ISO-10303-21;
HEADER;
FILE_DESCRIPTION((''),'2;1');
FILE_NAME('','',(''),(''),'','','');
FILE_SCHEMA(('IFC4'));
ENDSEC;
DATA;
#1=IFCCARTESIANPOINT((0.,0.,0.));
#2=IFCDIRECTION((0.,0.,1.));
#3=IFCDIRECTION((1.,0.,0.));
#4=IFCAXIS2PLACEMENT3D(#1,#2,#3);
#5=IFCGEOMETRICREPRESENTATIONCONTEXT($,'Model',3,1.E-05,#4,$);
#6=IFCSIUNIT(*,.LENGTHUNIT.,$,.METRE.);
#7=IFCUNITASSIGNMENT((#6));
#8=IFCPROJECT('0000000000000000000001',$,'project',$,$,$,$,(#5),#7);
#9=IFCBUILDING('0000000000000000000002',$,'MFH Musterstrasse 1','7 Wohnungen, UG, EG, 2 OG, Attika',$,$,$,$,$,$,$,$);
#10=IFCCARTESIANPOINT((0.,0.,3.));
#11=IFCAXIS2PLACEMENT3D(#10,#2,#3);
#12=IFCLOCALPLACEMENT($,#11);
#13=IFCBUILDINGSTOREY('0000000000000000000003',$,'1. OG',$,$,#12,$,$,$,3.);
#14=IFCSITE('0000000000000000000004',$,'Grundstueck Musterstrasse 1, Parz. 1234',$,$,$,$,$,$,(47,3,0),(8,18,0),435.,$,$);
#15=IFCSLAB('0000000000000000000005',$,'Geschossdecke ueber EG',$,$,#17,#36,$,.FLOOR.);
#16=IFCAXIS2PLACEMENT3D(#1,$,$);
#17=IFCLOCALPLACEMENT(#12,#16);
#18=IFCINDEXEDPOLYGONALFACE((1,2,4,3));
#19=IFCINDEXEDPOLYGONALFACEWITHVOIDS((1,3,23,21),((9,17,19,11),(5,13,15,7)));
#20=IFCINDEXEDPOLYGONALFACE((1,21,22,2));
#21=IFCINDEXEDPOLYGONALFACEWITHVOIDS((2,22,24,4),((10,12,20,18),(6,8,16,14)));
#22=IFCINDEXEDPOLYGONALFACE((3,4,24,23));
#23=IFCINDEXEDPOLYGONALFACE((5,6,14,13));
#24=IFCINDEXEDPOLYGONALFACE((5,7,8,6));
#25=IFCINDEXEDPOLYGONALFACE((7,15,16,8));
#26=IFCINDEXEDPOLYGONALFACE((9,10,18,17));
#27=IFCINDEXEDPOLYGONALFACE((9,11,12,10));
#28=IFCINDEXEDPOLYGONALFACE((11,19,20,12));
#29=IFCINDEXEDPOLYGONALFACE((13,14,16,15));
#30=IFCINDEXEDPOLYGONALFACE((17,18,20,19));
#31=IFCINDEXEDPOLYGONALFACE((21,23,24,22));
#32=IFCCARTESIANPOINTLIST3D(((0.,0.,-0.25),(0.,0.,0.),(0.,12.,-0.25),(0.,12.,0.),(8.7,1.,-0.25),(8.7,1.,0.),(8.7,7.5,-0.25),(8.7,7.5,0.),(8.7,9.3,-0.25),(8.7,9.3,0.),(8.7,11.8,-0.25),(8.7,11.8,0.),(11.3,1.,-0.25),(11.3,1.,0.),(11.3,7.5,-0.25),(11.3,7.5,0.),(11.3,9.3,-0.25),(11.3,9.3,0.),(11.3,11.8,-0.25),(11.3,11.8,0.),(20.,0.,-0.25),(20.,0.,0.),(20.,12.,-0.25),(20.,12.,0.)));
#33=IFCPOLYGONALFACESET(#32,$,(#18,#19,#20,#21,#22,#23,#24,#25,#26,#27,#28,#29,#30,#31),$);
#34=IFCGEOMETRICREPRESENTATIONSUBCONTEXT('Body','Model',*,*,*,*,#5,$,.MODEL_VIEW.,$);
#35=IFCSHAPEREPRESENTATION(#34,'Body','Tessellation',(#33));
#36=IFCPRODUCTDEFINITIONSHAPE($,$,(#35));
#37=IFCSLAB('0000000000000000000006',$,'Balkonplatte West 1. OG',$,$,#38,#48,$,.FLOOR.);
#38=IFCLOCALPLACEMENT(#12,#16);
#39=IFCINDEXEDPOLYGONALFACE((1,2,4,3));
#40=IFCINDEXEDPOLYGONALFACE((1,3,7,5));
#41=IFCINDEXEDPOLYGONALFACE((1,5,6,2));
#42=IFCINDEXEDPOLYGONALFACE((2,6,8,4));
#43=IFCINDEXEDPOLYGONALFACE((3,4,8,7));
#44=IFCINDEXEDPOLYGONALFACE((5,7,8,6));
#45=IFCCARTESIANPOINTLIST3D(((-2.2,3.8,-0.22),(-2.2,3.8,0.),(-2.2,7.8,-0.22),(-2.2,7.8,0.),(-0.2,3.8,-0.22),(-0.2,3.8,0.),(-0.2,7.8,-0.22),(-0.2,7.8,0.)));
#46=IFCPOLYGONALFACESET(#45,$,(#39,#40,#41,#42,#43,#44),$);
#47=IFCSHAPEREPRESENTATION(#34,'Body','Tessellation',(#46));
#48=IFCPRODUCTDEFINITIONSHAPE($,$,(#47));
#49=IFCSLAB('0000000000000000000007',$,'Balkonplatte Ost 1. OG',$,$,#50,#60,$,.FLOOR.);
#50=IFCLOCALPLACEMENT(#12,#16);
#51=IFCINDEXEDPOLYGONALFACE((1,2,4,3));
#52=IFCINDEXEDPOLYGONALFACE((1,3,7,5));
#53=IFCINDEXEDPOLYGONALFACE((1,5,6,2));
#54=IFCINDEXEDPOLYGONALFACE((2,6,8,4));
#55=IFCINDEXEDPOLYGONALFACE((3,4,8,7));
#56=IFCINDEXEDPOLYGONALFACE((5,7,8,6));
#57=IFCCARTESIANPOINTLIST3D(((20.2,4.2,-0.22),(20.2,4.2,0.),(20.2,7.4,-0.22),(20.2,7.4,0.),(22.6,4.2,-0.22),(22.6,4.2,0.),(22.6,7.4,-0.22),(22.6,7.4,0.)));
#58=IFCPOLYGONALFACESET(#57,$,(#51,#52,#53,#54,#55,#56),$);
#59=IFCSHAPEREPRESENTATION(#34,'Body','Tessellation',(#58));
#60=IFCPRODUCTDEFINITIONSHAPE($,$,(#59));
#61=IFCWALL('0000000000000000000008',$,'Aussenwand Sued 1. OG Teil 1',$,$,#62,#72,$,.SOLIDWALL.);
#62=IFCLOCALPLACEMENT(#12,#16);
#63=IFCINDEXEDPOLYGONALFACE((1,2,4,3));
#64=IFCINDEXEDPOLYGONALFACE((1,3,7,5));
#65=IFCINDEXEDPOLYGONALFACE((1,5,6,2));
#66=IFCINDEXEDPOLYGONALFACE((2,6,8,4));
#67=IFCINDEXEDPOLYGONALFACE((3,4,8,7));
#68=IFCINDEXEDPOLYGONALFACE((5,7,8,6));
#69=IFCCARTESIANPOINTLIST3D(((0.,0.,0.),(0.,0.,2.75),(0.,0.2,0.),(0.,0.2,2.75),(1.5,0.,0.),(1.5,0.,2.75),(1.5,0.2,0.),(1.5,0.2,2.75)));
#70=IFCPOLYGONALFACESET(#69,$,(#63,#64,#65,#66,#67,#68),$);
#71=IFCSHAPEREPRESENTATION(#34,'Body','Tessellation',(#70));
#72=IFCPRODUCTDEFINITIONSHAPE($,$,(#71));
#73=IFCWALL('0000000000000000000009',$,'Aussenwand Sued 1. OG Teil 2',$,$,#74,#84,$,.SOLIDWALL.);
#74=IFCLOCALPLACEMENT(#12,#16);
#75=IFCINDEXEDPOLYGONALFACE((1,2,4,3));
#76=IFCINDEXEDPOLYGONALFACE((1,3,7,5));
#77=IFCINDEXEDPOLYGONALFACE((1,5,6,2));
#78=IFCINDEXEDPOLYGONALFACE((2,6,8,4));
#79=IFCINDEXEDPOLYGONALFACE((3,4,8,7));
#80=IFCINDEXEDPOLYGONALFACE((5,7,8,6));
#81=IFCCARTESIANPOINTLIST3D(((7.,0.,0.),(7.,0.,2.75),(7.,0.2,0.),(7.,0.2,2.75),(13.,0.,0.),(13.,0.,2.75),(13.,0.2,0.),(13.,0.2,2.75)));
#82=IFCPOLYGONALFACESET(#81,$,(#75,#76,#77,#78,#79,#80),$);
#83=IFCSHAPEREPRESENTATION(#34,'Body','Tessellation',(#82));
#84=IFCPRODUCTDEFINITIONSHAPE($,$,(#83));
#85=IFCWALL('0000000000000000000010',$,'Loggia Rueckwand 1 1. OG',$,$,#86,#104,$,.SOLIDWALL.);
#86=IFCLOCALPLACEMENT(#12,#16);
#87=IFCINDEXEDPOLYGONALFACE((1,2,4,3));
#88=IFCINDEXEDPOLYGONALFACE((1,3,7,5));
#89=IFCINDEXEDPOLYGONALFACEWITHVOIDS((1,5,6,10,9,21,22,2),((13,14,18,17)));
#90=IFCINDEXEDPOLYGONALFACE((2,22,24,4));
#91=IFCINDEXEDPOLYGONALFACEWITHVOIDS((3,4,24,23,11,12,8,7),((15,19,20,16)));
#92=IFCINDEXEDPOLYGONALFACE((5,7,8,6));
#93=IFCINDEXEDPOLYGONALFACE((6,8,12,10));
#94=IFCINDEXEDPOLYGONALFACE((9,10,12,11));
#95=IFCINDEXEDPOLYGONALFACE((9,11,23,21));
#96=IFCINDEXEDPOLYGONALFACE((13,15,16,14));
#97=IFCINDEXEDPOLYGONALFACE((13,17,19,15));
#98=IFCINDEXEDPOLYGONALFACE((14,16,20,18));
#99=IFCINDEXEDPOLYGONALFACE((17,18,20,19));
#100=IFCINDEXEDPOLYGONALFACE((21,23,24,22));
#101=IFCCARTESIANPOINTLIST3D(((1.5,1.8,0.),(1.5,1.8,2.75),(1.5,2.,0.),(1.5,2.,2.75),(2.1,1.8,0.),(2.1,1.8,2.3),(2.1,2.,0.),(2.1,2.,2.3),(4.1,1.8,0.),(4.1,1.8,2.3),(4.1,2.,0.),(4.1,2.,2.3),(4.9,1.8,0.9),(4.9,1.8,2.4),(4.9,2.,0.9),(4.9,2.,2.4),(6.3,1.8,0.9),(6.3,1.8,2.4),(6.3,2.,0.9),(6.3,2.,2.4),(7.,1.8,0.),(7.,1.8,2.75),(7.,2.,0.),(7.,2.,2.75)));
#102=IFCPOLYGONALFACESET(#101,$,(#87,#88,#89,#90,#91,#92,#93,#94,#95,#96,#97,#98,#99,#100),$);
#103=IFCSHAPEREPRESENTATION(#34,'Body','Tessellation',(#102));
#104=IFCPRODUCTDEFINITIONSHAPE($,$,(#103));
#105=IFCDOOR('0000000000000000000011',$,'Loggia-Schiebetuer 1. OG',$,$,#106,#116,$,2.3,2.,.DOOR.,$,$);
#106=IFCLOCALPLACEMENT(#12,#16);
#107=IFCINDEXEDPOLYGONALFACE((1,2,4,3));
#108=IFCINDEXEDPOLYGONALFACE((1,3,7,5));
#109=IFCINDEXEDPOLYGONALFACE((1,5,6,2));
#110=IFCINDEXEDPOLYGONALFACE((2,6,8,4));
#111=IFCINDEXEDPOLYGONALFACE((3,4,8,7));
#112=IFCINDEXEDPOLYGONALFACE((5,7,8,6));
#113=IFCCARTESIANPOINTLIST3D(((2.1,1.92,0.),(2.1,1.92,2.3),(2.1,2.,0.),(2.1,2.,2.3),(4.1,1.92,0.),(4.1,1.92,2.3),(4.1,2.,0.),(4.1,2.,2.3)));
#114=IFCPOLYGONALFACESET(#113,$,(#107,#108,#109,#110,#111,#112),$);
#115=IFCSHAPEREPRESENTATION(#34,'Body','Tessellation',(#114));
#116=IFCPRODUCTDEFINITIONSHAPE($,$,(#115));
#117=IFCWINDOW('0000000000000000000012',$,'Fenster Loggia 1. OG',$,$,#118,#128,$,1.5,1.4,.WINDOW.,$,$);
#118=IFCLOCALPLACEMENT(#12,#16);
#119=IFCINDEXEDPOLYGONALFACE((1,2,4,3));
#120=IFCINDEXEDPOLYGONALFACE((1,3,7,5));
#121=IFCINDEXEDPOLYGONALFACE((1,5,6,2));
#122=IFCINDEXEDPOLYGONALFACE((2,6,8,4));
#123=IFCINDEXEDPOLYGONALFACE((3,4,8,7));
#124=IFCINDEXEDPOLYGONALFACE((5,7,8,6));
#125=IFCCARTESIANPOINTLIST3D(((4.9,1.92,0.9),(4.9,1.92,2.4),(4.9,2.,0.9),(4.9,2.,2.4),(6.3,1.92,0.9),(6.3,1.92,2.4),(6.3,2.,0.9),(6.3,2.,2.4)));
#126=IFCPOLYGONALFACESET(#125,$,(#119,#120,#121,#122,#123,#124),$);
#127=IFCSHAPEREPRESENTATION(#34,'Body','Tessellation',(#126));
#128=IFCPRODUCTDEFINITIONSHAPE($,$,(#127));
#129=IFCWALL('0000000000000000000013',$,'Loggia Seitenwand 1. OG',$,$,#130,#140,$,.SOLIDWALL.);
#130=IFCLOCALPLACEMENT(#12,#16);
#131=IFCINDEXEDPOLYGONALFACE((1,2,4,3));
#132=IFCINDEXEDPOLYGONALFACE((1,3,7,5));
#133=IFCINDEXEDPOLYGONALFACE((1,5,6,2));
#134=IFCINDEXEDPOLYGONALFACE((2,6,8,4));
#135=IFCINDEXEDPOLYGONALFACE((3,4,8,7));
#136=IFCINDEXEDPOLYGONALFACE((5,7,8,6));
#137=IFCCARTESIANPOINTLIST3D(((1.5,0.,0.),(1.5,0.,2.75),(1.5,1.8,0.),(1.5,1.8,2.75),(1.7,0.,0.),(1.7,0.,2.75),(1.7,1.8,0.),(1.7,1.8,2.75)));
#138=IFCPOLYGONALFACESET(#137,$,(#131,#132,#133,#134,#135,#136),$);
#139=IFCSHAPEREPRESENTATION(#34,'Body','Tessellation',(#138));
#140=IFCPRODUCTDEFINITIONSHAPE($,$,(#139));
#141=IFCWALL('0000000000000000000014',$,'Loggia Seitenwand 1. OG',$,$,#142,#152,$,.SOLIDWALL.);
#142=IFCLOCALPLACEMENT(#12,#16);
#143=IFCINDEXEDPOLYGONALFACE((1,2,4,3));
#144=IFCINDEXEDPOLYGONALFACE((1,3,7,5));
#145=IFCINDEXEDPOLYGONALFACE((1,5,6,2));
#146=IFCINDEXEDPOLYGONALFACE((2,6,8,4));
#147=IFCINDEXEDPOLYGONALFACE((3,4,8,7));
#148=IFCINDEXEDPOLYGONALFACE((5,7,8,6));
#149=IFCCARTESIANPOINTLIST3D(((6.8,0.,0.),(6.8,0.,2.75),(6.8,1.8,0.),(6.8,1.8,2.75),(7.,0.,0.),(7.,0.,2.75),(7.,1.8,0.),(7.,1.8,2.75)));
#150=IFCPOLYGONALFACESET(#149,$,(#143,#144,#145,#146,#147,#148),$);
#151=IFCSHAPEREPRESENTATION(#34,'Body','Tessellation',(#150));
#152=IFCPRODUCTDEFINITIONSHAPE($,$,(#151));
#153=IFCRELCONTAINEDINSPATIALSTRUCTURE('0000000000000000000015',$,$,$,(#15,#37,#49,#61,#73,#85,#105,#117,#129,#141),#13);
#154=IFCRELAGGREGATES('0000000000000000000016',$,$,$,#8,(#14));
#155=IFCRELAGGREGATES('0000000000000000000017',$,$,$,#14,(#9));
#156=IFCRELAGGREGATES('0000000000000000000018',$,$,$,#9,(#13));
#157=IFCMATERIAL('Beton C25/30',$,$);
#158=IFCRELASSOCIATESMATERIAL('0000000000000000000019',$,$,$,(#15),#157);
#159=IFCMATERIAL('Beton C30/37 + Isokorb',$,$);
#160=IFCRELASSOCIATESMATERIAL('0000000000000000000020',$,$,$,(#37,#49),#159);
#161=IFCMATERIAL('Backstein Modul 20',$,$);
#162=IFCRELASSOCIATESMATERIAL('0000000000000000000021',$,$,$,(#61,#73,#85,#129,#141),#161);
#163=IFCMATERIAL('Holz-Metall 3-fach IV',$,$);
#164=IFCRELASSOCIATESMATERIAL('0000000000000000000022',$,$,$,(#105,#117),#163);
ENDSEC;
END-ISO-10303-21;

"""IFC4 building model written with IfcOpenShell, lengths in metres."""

from ifc_helpers import new_model, si_unit, frame, frame_2d, origin_with_axes, place, context, subcontext, project, spatial, polyline, rectangle, outline, extrude, material, element, fill, save


model = new_model("IFC4")

# Units and contexts
model_context = context("Model", 3, precision=1e-05, world=origin_with_axes())
body_context = subcontext(model_context, "Body", "Model", "MODEL_VIEW")
ifc_project = project(units=[si_unit("LENGTHUNIT", "METRE")], contexts=[model_context])

# Site, building, storey
site = spatial("IfcSite", under=ifc_project, Name="Grundstueck Musterstrasse 1, Parz. 1234", RefLatitude=(47, 3, 0), RefLongitude=(8, 18, 0), RefElevation=435.0)
building = spatial("IfcBuilding", under=site, Name="MFH Musterstrasse 1", Description="7 Wohnungen, UG, EG, 2 OG, Attika")
storey_placement = place(None, frame((0.0, 0.0, 3.0), z_axis=(0.0, 0.0, 1.0), x_axis=(1.0, 0.0, 0.0)))
storey = spatial("IfcBuildingStorey", under=building, at=storey_placement, Name="1. OG", Elevation=3.0)

# Slab, openings
ifc_material_1 = material(Name="Beton C25/30")
slab_1_placement = place(storey_placement, frame((0.0, 0.0, -0.25), z_axis=(0.0, 0.0, 1.0), x_axis=(1.0, 0.0, 0.0)))
slab_1 = element("IfcSlab", 1, at=slab_1_placement, inside=storey, material=ifc_material_1, Name="Geschossdecke ueber EG", PredefinedType="FLOOR", context=body_context, shape_type="SweptSolid", body=[
    extrude(outline(polyline([(0.0, 0.0), (20.0, 0.0), (20.0, 12.0), (0.0, 12.0), (0.0, 0.0)])), origin_with_axes(), (0.0, 0.0, 1.0), 0.25),
])
opening_1_placement = place(slab_1_placement, frame((8.7, 1.0, -0.01), z_axis=(0.0, 0.0, 1.0), x_axis=(1.0, 0.0, 0.0)))
element("IfcOpeningElement", 2, at=opening_1_placement, cuts=slab_1, context=body_context, shape_type="SweptSolid", body=[
    extrude(rectangle(XDim=2.6, YDim=6.5, at=frame_2d((1.3, 3.25))), origin_with_axes(), (0.0, 0.0, 1.0), 0.27),
])
opening_2_placement = place(slab_1_placement, frame((8.7, 9.3, -0.01), z_axis=(0.0, 0.0, 1.0), x_axis=(1.0, 0.0, 0.0)))
element("IfcOpeningElement", 3, at=opening_2_placement, cuts=slab_1, context=body_context, shape_type="SweptSolid", body=[
    extrude(rectangle(XDim=2.6, YDim=2.5, at=frame_2d((1.3, 1.25))), origin_with_axes(), (0.0, 0.0, 1.0), 0.27),
])

# Slabs
ifc_material_2 = material(Name="Beton C30/37 + Isokorb")
slab_2_placement = place(storey_placement, frame((0.0, 0.0, -0.22), z_axis=(0.0, 0.0, 1.0), x_axis=(1.0, 0.0, 0.0)))
element("IfcSlab", 4, at=slab_2_placement, inside=storey, material=ifc_material_2, Name="Balkonplatte West 1. OG", PredefinedType="FLOOR", context=body_context, shape_type="SweptSolid", body=[
    extrude(outline(polyline([(-2.2, 3.8), (-0.2, 3.8), (-0.2, 7.8), (-2.2, 7.8), (-2.2, 3.8)])), origin_with_axes(), (0.0, 0.0, 1.0), 0.22),
])
slab_3_placement = place(storey_placement, frame((0.0, 0.0, -0.22), z_axis=(0.0, 0.0, 1.0), x_axis=(1.0, 0.0, 0.0)))
element("IfcSlab", 5, at=slab_3_placement, inside=storey, material=ifc_material_2, Name="Balkonplatte Ost 1. OG", PredefinedType="FLOOR", context=body_context, shape_type="SweptSolid", body=[
    extrude(outline(polyline([(20.2, 4.2), (22.6, 4.2), (22.6, 7.4), (20.2, 7.4), (20.2, 4.2)])), origin_with_axes(), (0.0, 0.0, 1.0), 0.22),
])

# Walls
ifc_material_3 = material(Name="Backstein Modul 20")
wall_1_placement = place(storey_placement, origin_with_axes())
element("IfcWall", 6, at=wall_1_placement, inside=storey, material=ifc_material_3, Name="Aussenwand Sued 1. OG Teil 1", PredefinedType="SOLIDWALL", context=body_context, shape_type="SweptSolid", body=[
    extrude(rectangle(XDim=1.5, YDim=0.2, at=frame_2d((0.75, 0.1))), origin_with_axes(), (0.0, 0.0, 1.0), 2.75),
])
wall_2_placement = place(storey_placement, frame((7.0, 0.0, 0.0), z_axis=(0.0, 0.0, 1.0), x_axis=(1.0, 0.0, 0.0)))
element("IfcWall", 7, at=wall_2_placement, inside=storey, material=ifc_material_3, Name="Aussenwand Sued 1. OG Teil 2", PredefinedType="SOLIDWALL", context=body_context, shape_type="SweptSolid", body=[
    extrude(rectangle(XDim=6.0, YDim=0.2, at=frame_2d((3.0, 0.1))), origin_with_axes(), (0.0, 0.0, 1.0), 2.75),
])

# Wall, openings, door, window
wall_3_placement = place(storey_placement, frame((1.5, 1.8, 0.0), z_axis=(0.0, 0.0, 1.0), x_axis=(1.0, 0.0, 0.0)))
wall_3 = element("IfcWall", 8, at=wall_3_placement, inside=storey, material=ifc_material_3, Name="Loggia Rueckwand 1 1. OG", PredefinedType="SOLIDWALL", context=body_context, shape_type="SweptSolid", body=[
    extrude(rectangle(XDim=5.5, YDim=0.2, at=frame_2d((2.75, 0.1))), origin_with_axes(), (0.0, 0.0, 1.0), 2.75),
])
opening_3_placement = place(wall_3_placement, frame((0.6, -0.21, 0.0), z_axis=(0.0, 0.0, 1.0), x_axis=(1.0, 0.0, 0.0)))
opening_3 = element("IfcOpeningElement", 9, at=opening_3_placement, cuts=wall_3, context=body_context, shape_type="SweptSolid", body=[
    extrude(rectangle(XDim=2.0, YDim=0.42, at=frame_2d((1.0, 0.21))), origin_with_axes(), (0.0, 0.0, 1.0), 2.3),
])
opening_4_placement = place(wall_3_placement, frame((3.4, -0.21, 0.9), z_axis=(0.0, 0.0, 1.0), x_axis=(1.0, 0.0, 0.0)))
opening_4 = element("IfcOpeningElement", 10, at=opening_4_placement, cuts=wall_3, context=body_context, shape_type="SweptSolid", body=[
    extrude(rectangle(XDim=1.4, YDim=0.42, at=frame_2d((0.7, 0.21))), origin_with_axes(), (0.0, 0.0, 1.0), 1.5),
])
ifc_material_4 = material(Name="Holz-Metall 3-fach IV")
door_1_placement = place(storey_placement, frame((2.1, 1.92, 0.0), z_axis=(0.0, 0.0, 1.0), x_axis=(1.0, 0.0, 0.0)))
door_1 = element("IfcDoor", 11, at=door_1_placement, inside=storey, material=ifc_material_4, Name="Loggia-Schiebetuer 1. OG", OverallHeight=2.3, OverallWidth=2.0, PredefinedType="DOOR", context=body_context, shape_type="SweptSolid", body=[
    extrude(rectangle(XDim=2.0, YDim=0.08, at=frame_2d((1.0, 0.04))), origin_with_axes(), (0.0, 0.0, 1.0), 2.3),
])
fill(opening_3, door_1)
window_1_placement = place(storey_placement, frame((4.9, 1.92, 0.9), z_axis=(0.0, 0.0, 1.0), x_axis=(1.0, 0.0, 0.0)))
window_1 = element("IfcWindow", 12, at=window_1_placement, inside=storey, material=ifc_material_4, Name="Fenster Loggia 1. OG", OverallHeight=1.5, OverallWidth=1.4, PredefinedType="WINDOW", context=body_context, shape_type="SweptSolid", body=[
    extrude(rectangle(XDim=1.4, YDim=0.08, at=frame_2d((0.7, 0.04))), origin_with_axes(), (0.0, 0.0, 1.0), 1.5),
])
fill(opening_4, window_1)

# Walls
for number, where, z_axis, x_axis, name in (
    (13, (1.5, 0.2, 0.0), (0.0, 0.0, 1.0), (1.0, 0.0, 0.0), "Loggia Seitenwand 1. OG"),
    (14, (6.8, 0.2, 0.0), (0.0, 0.0, 1.0), (1.0, 0.0, 0.0), "Loggia Seitenwand 1. OG"),
):
    element("IfcWall", number, at=place(storey_placement, frame(where, z_axis=z_axis, x_axis=x_axis)), inside=storey, material=ifc_material_3, Name=name, PredefinedType="SOLIDWALL", context=body_context, shape_type="SweptSolid", body=[
        extrude(rectangle(XDim=0.2, YDim=1.8, at=frame_2d((0.1, 0.7))), origin_with_axes(), (0.0, 0.0, 1.0), 2.75),
    ])

save(model, "model.ifc")
